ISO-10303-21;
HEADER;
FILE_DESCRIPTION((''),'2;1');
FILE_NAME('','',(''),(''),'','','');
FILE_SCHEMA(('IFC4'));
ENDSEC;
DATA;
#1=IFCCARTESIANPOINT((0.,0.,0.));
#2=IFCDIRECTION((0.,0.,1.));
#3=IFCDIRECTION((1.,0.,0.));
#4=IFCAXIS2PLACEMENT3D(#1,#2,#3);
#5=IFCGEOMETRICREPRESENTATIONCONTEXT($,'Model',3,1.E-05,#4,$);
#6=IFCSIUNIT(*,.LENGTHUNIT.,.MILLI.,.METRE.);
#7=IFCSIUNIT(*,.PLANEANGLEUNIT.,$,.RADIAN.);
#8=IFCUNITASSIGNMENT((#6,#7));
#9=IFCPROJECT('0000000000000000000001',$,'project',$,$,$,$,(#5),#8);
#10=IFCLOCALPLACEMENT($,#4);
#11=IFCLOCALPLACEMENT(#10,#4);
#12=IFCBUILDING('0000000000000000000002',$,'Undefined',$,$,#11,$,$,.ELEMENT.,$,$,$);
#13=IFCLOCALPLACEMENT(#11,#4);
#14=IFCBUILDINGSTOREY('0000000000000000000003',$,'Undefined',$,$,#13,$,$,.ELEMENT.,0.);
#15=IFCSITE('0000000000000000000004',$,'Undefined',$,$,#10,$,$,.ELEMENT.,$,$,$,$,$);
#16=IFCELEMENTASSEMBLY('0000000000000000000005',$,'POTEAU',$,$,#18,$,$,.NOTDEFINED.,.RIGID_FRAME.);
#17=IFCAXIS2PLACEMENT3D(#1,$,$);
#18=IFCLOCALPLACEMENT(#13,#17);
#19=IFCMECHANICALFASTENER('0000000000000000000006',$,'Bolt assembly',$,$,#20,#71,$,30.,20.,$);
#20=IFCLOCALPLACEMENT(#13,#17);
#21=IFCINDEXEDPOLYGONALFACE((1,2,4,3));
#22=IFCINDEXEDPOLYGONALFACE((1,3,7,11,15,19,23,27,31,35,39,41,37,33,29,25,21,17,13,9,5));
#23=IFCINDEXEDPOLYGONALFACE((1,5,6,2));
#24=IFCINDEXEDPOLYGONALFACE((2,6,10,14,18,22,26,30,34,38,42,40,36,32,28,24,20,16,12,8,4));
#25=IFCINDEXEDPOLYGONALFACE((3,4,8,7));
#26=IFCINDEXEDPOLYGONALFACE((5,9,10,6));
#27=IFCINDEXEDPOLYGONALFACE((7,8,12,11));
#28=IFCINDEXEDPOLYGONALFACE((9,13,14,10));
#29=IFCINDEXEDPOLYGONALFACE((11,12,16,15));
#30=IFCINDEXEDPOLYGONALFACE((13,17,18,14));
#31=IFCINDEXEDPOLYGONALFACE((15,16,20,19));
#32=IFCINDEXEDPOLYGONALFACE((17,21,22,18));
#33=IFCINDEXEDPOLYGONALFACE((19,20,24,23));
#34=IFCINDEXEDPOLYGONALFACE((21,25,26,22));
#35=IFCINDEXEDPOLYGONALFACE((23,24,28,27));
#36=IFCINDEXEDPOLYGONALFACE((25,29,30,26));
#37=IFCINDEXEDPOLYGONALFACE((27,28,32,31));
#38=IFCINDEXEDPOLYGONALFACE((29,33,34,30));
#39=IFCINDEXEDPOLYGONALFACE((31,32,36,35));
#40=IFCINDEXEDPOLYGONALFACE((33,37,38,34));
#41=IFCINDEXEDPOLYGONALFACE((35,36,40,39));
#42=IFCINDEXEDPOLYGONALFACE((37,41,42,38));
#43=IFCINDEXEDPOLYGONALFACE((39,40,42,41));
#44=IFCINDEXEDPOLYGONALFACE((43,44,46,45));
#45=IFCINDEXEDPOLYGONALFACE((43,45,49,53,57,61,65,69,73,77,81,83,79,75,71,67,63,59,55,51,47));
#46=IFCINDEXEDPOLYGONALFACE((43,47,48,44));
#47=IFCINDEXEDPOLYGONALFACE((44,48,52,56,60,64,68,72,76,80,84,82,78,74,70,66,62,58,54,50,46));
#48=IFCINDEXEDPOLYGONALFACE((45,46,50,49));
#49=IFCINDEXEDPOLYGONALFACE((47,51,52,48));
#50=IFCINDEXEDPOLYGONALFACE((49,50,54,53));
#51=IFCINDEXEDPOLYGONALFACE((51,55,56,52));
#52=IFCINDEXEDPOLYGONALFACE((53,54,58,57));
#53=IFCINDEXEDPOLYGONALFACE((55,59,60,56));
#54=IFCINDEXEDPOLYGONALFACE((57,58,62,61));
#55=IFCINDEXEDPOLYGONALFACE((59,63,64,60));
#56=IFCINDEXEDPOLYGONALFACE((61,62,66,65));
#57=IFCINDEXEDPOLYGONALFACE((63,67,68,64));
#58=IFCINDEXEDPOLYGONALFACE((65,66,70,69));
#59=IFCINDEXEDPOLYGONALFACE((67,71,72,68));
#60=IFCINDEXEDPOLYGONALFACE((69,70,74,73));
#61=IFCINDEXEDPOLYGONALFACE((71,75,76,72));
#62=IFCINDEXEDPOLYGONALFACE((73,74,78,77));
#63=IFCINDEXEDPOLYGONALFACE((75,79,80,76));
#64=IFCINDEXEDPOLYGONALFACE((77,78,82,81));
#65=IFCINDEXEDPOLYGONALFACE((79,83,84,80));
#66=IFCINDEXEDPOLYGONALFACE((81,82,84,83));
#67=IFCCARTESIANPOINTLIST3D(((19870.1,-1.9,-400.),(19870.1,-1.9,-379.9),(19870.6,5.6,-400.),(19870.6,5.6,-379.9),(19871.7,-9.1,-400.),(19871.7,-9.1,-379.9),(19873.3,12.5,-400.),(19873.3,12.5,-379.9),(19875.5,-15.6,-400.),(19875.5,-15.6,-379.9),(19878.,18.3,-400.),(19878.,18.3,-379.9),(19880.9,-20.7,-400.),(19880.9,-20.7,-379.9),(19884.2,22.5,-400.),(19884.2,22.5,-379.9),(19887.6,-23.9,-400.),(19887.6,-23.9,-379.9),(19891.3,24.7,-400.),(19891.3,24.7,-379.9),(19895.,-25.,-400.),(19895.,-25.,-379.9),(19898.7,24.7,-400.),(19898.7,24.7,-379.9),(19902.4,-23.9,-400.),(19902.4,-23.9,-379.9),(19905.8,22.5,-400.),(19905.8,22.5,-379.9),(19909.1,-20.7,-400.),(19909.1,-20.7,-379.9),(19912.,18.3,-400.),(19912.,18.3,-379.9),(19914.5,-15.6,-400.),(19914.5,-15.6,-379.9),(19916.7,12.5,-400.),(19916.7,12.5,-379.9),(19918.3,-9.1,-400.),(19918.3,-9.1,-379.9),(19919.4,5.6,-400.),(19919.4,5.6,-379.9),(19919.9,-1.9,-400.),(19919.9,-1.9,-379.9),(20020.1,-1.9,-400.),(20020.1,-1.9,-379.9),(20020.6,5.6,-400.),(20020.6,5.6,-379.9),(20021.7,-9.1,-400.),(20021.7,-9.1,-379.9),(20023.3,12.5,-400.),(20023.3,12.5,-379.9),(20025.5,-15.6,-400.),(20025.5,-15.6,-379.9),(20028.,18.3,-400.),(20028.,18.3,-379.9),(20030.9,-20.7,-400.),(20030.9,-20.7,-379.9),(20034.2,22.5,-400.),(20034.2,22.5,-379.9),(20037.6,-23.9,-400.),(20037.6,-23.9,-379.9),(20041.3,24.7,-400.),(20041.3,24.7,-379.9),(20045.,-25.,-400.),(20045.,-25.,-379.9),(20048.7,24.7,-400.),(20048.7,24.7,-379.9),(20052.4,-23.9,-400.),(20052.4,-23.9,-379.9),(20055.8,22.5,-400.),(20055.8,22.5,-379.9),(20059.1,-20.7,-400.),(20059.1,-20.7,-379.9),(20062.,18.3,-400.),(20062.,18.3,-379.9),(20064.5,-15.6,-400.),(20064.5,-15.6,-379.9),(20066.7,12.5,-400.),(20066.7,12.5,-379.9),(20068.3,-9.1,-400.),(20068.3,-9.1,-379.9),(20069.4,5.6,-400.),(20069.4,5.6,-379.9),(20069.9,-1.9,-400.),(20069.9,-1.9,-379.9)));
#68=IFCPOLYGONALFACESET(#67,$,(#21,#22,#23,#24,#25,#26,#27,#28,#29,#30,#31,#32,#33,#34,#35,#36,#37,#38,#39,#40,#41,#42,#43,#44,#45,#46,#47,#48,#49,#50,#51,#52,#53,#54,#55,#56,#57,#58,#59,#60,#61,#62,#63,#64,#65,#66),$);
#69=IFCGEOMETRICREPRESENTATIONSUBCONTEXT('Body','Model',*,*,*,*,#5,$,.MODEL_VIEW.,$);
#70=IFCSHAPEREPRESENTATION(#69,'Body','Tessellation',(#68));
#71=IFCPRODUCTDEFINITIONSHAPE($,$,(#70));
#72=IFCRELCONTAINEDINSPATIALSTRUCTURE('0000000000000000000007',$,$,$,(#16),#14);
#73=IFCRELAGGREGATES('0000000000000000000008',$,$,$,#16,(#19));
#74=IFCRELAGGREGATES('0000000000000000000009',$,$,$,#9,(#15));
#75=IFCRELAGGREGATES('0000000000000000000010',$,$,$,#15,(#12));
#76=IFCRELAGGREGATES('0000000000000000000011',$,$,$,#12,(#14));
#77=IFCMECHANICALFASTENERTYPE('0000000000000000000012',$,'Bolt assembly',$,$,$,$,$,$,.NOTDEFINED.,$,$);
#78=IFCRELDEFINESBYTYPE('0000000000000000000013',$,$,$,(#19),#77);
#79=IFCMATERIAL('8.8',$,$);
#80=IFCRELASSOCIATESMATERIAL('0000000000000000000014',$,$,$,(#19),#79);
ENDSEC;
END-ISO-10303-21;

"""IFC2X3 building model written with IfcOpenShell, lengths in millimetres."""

from ifc_helpers import new_model, si_unit, frame, origin_with_axes, origin_2d_with_axis, place, context, subcontext, project, spatial, circle, extrude, source, transform, mapped, material, type_object, element, aggregate, save


model = new_model("IFC2X3")

# Units and contexts
model_context = context("Model", 3, precision=1e-05, world=origin_with_axes())
body_context = subcontext(model_context, "Body", "Model", "MODEL_VIEW")
ifc_project = project(units=[si_unit("LENGTHUNIT", "METRE", prefix="MILLI"), si_unit("PLANEANGLEUNIT", "RADIAN")], contexts=[model_context])

# Site, building, storey
site_placement = place(None, origin_with_axes())
site = spatial("IfcSite", under=ifc_project, at=site_placement, Name="Undefined", CompositionType="ELEMENT")
building_placement = place(site_placement, origin_with_axes())
building = spatial("IfcBuilding", under=site, at=building_placement, Name="Undefined", CompositionType="ELEMENT")
storey_placement = place(building_placement, origin_with_axes())
storey = spatial("IfcBuildingStorey", under=building, at=storey_placement, Name="Undefined", CompositionType="ELEMENT", Elevation=0.0)

# Element assembly
assembly_1_placement = place(storey_placement, origin_with_axes())
assembly_1 = element("IfcElementAssembly", 1, at=assembly_1_placement, inside=storey, Name="POTEAU", AssemblyPlace="NOTDEFINED", PredefinedType="RIGID_FRAME")

# Shared definitions
mechanical_fastener_type = type_object("IfcMechanicalFastenerType", Name="Bolt assembly")

# Mechanical fastener
ifc_material_1 = material(Name="8.8")
shared_shape_1 = source(origin_with_axes(), body_context, "Body", "SweptSolid", [
    extrude(circle(Radius=25.0, at=origin_2d_with_axis()), frame((0.0, 0.0, 0.0), z_axis=(0.0, 1.0, 0.0), x_axis=(1.0, 0.0, 0.0)), (0.0, 0.0, 1.0), 20.1),
])
mechanical_fastener_1_placement = place(assembly_1_placement, frame((19970.0, 0.0, -400.0), z_axis=(-1.0, 0.0, 0.0), x_axis=(0.0, -1.0, 0.0)))
mechanical_fastener_1 = element("IfcMechanicalFastener", 2, at=mechanical_fastener_1_placement, type_object=mechanical_fastener_type, material=ifc_material_1, Name="Bolt assembly", NominalDiameter=30.0, NominalLength=20.0, context=body_context, shape_type="MappedRepresentation", body=[
    mapped(shared_shape_1, transform((0.0, 0.0, -75.0))),
    mapped(shared_shape_1, transform((0.0, 0.0, 75.0))),
])
aggregate(assembly_1, [mechanical_fastener_1])

save(model, "model.ifc")
